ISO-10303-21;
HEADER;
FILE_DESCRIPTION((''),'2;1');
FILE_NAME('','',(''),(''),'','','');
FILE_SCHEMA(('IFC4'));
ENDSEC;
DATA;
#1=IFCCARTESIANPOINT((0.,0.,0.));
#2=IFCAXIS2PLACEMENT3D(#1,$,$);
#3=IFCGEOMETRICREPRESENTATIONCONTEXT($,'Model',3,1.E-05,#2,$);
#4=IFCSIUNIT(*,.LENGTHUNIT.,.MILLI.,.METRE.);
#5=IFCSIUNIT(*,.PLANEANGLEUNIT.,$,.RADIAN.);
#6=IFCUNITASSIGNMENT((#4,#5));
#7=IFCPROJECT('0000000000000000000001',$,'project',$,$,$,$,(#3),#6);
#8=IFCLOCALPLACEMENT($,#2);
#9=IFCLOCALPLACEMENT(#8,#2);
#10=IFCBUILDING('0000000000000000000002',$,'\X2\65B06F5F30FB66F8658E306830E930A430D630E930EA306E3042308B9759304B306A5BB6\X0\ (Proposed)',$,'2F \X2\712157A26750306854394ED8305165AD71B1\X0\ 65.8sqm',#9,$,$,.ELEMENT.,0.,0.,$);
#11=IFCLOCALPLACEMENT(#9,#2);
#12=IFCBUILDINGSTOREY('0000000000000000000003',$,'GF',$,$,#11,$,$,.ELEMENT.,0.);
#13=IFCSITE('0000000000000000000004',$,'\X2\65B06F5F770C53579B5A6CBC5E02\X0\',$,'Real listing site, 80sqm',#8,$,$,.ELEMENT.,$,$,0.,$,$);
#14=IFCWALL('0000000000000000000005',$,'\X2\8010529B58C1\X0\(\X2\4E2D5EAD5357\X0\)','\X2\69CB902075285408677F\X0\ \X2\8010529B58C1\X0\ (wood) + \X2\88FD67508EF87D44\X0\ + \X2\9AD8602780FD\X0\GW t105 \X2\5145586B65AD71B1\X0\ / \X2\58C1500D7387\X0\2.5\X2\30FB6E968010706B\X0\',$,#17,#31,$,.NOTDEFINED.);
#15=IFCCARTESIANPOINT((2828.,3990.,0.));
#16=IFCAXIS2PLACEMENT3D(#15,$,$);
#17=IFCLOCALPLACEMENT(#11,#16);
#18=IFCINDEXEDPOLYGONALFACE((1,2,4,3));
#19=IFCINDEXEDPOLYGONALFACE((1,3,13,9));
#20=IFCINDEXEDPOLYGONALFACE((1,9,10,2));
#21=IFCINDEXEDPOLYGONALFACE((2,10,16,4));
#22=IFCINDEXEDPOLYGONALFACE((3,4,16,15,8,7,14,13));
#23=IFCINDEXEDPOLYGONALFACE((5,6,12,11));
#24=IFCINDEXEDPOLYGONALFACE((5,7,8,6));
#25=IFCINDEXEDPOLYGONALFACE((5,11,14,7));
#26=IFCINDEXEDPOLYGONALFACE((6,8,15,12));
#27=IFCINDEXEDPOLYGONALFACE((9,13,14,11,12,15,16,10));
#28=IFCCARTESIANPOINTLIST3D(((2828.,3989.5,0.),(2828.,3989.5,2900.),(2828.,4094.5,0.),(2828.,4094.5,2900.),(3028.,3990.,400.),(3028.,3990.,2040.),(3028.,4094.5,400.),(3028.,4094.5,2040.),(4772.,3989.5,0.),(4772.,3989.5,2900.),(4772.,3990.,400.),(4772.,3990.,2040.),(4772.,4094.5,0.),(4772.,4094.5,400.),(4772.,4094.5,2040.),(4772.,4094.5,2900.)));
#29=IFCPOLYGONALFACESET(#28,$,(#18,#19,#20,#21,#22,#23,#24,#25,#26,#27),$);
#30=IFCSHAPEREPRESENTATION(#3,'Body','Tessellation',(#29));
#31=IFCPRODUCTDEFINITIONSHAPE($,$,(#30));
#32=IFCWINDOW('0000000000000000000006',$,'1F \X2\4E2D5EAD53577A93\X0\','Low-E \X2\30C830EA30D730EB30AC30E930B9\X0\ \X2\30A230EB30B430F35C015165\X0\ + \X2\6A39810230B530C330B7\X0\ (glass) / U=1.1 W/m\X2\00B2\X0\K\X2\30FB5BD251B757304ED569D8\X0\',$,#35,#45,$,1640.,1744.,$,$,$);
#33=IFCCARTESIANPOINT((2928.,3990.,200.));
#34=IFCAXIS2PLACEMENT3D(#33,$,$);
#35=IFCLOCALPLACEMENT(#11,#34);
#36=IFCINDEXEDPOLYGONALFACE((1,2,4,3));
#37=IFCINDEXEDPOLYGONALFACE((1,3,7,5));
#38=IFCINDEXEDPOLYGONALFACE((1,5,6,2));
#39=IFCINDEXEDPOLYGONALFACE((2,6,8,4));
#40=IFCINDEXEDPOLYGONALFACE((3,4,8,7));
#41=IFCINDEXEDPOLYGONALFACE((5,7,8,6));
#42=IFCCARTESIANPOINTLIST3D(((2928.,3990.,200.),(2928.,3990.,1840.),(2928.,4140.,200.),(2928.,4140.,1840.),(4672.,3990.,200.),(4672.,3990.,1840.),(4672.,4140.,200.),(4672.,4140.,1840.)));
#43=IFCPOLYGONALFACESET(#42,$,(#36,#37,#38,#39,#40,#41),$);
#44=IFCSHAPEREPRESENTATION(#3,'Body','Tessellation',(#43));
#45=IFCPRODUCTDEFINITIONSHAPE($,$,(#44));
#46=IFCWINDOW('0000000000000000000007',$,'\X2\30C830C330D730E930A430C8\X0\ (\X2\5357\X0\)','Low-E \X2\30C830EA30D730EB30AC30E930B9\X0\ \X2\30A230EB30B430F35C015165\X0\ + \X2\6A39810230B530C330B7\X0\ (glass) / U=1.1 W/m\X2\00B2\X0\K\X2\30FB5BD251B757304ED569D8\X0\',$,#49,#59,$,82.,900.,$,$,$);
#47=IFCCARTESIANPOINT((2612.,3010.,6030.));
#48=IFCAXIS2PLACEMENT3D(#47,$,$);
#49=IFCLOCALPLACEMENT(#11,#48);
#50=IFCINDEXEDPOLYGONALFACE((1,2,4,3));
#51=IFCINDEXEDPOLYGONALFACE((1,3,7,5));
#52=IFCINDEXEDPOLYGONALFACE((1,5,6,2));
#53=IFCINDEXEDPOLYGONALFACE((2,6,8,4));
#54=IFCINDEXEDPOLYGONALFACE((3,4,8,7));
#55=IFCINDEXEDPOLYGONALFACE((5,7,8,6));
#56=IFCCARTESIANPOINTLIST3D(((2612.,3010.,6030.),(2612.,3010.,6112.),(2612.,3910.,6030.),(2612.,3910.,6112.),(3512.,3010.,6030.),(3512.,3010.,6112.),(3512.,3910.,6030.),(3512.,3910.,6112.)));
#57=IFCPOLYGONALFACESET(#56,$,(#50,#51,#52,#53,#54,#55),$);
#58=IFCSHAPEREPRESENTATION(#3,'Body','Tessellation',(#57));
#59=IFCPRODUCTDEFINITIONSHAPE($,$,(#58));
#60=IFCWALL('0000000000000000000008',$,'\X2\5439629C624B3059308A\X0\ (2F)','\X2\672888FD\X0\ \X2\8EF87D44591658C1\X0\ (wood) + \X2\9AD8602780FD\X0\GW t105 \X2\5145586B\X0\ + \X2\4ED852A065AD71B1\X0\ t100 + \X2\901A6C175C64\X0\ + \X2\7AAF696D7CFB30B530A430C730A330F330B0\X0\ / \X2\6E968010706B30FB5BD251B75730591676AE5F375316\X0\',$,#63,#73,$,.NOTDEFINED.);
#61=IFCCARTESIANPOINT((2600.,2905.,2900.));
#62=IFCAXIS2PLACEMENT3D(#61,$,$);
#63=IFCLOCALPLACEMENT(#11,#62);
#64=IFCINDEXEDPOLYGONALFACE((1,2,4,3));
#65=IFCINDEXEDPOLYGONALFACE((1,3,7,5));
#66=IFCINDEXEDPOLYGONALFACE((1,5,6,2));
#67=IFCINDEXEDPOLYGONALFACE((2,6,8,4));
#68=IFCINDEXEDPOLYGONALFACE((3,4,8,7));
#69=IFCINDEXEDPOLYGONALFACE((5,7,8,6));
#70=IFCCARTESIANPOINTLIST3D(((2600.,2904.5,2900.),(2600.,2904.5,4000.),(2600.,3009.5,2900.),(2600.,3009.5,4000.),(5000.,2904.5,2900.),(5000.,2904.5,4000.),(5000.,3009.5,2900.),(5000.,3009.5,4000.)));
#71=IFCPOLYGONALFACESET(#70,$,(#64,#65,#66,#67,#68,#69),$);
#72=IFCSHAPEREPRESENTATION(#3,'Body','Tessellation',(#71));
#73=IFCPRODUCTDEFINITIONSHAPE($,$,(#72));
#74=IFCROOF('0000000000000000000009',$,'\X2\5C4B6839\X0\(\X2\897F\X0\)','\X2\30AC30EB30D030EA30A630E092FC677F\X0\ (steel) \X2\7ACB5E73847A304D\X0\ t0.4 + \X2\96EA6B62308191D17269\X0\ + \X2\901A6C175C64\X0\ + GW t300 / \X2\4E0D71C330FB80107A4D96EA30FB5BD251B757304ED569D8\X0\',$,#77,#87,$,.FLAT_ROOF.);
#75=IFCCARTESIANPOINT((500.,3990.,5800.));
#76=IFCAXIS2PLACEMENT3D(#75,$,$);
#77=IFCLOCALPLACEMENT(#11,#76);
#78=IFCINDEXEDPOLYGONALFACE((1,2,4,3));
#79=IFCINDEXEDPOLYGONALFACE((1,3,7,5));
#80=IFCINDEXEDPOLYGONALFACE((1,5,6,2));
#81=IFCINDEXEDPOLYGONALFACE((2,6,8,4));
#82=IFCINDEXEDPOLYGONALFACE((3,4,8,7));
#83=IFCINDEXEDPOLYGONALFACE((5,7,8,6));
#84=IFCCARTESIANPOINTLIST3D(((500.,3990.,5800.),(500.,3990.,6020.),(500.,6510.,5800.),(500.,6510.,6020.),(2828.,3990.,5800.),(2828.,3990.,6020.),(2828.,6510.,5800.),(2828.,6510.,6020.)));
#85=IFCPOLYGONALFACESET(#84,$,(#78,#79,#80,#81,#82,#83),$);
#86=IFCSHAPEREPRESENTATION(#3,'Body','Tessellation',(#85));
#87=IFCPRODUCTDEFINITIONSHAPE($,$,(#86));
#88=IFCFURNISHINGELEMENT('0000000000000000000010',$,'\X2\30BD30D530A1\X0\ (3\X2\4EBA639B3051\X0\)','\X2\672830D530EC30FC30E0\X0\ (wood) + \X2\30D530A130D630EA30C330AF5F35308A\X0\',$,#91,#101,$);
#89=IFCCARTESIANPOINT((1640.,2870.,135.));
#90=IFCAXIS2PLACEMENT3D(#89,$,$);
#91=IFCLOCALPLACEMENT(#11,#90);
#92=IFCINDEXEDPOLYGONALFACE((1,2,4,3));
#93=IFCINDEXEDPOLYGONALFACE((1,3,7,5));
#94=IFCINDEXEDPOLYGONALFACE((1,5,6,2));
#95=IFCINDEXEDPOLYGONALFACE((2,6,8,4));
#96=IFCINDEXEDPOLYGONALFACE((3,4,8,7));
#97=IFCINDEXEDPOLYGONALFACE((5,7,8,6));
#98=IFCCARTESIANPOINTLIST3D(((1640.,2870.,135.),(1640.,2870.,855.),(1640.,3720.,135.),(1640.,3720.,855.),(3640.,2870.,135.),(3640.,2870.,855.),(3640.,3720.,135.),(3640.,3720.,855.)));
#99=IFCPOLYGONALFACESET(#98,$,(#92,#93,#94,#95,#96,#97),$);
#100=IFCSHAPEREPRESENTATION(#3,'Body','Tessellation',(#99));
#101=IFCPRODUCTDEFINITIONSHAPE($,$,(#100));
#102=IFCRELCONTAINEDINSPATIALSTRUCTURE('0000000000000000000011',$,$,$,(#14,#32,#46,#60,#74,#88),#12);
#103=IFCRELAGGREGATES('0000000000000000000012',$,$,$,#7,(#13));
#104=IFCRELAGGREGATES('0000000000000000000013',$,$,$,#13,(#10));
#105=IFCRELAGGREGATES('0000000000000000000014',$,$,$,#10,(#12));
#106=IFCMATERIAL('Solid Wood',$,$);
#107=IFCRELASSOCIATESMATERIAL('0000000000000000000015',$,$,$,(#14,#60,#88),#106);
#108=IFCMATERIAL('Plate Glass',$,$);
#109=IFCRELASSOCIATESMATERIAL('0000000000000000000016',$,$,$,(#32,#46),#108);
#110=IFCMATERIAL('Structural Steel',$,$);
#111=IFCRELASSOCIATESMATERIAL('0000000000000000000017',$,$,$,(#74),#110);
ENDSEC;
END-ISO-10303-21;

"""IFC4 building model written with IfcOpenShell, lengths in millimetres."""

from ifc_helpers import new_model, si_unit, frame, frame_2d, origin, place, context, project, spatial, rectangle, extrude, material, element, fill, save


model = new_model("IFC4")

# Units and contexts
model_context = context("Model", 3, precision=1e-05, world=origin())
ifc_project = project(units=[si_unit("LENGTHUNIT", "METRE", prefix="MILLI"), si_unit("PLANEANGLEUNIT", "RADIAN")], contexts=[model_context])

# Site, building, storey
site_placement = place(None, origin())
site = spatial("IfcSite", under=ifc_project, at=site_placement, Name="新潟県南魚沼市", ObjectType="Real listing site, 80sqm", CompositionType="ELEMENT", RefElevation=0.0)
building_placement = place(site_placement, origin())
building = spatial("IfcBuilding", under=site, at=building_placement, Name="新潟・書斎とライブラリのある静かな家 (Proposed)", ObjectType="2F 無垢材と吹付け断熱 65.8sqm", CompositionType="ELEMENT", ElevationOfRefHeight=0.0, ElevationOfTerrain=0.0)
storey_placement = place(building_placement, origin())
storey = spatial("IfcBuildingStorey", under=building, at=storey_placement, Name="GF", CompositionType="ELEMENT", Elevation=0.0)

# Shared definitions
ifc_material_1 = material(Name="Solid Wood")

# Wall, opening, window
wall_1_placement = place(storey_placement, frame((2828.0, 3990.0, 0.0)))
wall_1 = element("IfcWall", 1, at=wall_1_placement, inside=storey, material=ifc_material_1, Name="耐力壁(中庭南)", Description="構造用合板 耐力壁 (wood) + 製材軸組 + 高性能GW t105 充填断熱 / 壁倍率2.5・準耐火", PredefinedType="NOTDEFINED", context=model_context, shape_type="SweptSolid", body=[
    extrude(rectangle(XDim=1944.0, YDim=105.0, at=frame_2d((972.0, 52.0))), frame((2828.0, 3990.0, 0.0)), (0.0, 0.0, 1.0), 2900.0),
])
opening_placement = place(storey_placement, frame((2928.0, 3990.0, 200.0)))
opening = element("IfcOpeningElement", 2, at=opening_placement, cuts=wall_1, PredefinedType="NOTDEFINED", context=model_context, shape_type="SweptSolid", body=[
    extrude(rectangle(XDim=1744.0, YDim=150.0, at=frame_2d((872.0, 75.0))), frame((2928.0, 3990.0, 200.0)), (0.0, 0.0, 1.0), 1640.0),
])
ifc_material_2 = material(Name="Plate Glass")
window_1_placement = place(storey_placement, frame((2928.0, 3990.0, 200.0)))
window_1 = element("IfcWindow", 3, at=window_1_placement, inside=storey, material=ifc_material_2, Name="1F 中庭南窓", Description="Low-E トリプルガラス アルゴン封入 + 樹脂サッシ (glass) / U=1.1 W/m²K・寒冷地仕様", OverallHeight=1640.0, OverallWidth=1744.0, context=model_context, shape_type="SweptSolid", body=[
    extrude(rectangle(XDim=1744.0, YDim=150.0, at=frame_2d((872.0, 75.0))), frame((2928.0, 3990.0, 200.0)), (0.0, 0.0, 1.0), 1640.0),
])
fill(opening, window_1)

# Window
window_2_placement = place(storey_placement, frame((2612.0, 3010.0, 6030.0)))
element("IfcWindow", 4, at=window_2_placement, inside=storey, material=ifc_material_2, Name="トップライト (南)", Description="Low-E トリプルガラス アルゴン封入 + 樹脂サッシ (glass) / U=1.1 W/m²K・寒冷地仕様", OverallHeight=82.0, OverallWidth=900.0, context=model_context, shape_type="SweptSolid", body=[
    extrude(rectangle(XDim=900.0, YDim=900.0, at=frame_2d((450.0, 450.0))), frame((2612.0, 3010.0, 6030.0)), (0.0, 0.0, 1.0), 82.0),
])

# Wall
wall_2_placement = place(storey_placement, frame((2600.0, 2905.0, 2900.0)))
element("IfcWall", 5, at=wall_2_placement, inside=storey, material=ifc_material_1, Name="吹抜手すり (2F)", Description="木製 軸組外壁 (wood) + 高性能GW t105 充填 + 付加断熱 t100 + 通気層 + 窯業系サイディング / 準耐火・寒冷地外皮強化", PredefinedType="NOTDEFINED", context=model_context, shape_type="SweptSolid", body=[
    extrude(rectangle(XDim=2400.0, YDim=105.0, at=frame_2d((1200.0, 52.0))), frame((2600.0, 2905.0, 2900.0)), (0.0, 0.0, 1.0), 1100.0),
])

# Roof
ifc_material_3 = material(Name="Structural Steel")
for number, where, name in (
    (6, (500.0, 3990.0, 5800.0), "屋根(西)"),
):
    element("IfcRoof", number, at=place(storey_placement, frame(where)), inside=storey, material=ifc_material_3, Name=name, Description="ガルバリウム鋼板 (steel) 立平葺き t0.4 + 雪止め金物 + 通気層 + GW t300 / 不燃・耐積雪・寒冷地仕様", PredefinedType="FLAT_ROOF", context=model_context, shape_type="SweptSolid", body=[
        extrude(rectangle(XDim=2328.0, YDim=2520.0, at=frame_2d((1164.0, 1260.0))), frame((500.0, 3990.0, 5800.0)), (0.0, 0.0, 1.0), 220.0),
    ])

# Furnishing element
furnishing_placement = place(storey_placement, frame((1640.0, 2870.0, 135.0)))
element("IfcFurnishingElement", 7, at=furnishing_placement, inside=storey, material=ifc_material_1, Name="ソファ (3人掛け)", Description="木フレーム (wood) + ファブリック張り", context=model_context, shape_type="SweptSolid", body=[
    extrude(rectangle(XDim=2000.0, YDim=850.0, at=frame_2d((1000.0, 425.0))), frame((1640.0, 2870.0, 135.0)), (0.0, 0.0, 1.0), 720.0),
])

save(model, "model.ifc")
